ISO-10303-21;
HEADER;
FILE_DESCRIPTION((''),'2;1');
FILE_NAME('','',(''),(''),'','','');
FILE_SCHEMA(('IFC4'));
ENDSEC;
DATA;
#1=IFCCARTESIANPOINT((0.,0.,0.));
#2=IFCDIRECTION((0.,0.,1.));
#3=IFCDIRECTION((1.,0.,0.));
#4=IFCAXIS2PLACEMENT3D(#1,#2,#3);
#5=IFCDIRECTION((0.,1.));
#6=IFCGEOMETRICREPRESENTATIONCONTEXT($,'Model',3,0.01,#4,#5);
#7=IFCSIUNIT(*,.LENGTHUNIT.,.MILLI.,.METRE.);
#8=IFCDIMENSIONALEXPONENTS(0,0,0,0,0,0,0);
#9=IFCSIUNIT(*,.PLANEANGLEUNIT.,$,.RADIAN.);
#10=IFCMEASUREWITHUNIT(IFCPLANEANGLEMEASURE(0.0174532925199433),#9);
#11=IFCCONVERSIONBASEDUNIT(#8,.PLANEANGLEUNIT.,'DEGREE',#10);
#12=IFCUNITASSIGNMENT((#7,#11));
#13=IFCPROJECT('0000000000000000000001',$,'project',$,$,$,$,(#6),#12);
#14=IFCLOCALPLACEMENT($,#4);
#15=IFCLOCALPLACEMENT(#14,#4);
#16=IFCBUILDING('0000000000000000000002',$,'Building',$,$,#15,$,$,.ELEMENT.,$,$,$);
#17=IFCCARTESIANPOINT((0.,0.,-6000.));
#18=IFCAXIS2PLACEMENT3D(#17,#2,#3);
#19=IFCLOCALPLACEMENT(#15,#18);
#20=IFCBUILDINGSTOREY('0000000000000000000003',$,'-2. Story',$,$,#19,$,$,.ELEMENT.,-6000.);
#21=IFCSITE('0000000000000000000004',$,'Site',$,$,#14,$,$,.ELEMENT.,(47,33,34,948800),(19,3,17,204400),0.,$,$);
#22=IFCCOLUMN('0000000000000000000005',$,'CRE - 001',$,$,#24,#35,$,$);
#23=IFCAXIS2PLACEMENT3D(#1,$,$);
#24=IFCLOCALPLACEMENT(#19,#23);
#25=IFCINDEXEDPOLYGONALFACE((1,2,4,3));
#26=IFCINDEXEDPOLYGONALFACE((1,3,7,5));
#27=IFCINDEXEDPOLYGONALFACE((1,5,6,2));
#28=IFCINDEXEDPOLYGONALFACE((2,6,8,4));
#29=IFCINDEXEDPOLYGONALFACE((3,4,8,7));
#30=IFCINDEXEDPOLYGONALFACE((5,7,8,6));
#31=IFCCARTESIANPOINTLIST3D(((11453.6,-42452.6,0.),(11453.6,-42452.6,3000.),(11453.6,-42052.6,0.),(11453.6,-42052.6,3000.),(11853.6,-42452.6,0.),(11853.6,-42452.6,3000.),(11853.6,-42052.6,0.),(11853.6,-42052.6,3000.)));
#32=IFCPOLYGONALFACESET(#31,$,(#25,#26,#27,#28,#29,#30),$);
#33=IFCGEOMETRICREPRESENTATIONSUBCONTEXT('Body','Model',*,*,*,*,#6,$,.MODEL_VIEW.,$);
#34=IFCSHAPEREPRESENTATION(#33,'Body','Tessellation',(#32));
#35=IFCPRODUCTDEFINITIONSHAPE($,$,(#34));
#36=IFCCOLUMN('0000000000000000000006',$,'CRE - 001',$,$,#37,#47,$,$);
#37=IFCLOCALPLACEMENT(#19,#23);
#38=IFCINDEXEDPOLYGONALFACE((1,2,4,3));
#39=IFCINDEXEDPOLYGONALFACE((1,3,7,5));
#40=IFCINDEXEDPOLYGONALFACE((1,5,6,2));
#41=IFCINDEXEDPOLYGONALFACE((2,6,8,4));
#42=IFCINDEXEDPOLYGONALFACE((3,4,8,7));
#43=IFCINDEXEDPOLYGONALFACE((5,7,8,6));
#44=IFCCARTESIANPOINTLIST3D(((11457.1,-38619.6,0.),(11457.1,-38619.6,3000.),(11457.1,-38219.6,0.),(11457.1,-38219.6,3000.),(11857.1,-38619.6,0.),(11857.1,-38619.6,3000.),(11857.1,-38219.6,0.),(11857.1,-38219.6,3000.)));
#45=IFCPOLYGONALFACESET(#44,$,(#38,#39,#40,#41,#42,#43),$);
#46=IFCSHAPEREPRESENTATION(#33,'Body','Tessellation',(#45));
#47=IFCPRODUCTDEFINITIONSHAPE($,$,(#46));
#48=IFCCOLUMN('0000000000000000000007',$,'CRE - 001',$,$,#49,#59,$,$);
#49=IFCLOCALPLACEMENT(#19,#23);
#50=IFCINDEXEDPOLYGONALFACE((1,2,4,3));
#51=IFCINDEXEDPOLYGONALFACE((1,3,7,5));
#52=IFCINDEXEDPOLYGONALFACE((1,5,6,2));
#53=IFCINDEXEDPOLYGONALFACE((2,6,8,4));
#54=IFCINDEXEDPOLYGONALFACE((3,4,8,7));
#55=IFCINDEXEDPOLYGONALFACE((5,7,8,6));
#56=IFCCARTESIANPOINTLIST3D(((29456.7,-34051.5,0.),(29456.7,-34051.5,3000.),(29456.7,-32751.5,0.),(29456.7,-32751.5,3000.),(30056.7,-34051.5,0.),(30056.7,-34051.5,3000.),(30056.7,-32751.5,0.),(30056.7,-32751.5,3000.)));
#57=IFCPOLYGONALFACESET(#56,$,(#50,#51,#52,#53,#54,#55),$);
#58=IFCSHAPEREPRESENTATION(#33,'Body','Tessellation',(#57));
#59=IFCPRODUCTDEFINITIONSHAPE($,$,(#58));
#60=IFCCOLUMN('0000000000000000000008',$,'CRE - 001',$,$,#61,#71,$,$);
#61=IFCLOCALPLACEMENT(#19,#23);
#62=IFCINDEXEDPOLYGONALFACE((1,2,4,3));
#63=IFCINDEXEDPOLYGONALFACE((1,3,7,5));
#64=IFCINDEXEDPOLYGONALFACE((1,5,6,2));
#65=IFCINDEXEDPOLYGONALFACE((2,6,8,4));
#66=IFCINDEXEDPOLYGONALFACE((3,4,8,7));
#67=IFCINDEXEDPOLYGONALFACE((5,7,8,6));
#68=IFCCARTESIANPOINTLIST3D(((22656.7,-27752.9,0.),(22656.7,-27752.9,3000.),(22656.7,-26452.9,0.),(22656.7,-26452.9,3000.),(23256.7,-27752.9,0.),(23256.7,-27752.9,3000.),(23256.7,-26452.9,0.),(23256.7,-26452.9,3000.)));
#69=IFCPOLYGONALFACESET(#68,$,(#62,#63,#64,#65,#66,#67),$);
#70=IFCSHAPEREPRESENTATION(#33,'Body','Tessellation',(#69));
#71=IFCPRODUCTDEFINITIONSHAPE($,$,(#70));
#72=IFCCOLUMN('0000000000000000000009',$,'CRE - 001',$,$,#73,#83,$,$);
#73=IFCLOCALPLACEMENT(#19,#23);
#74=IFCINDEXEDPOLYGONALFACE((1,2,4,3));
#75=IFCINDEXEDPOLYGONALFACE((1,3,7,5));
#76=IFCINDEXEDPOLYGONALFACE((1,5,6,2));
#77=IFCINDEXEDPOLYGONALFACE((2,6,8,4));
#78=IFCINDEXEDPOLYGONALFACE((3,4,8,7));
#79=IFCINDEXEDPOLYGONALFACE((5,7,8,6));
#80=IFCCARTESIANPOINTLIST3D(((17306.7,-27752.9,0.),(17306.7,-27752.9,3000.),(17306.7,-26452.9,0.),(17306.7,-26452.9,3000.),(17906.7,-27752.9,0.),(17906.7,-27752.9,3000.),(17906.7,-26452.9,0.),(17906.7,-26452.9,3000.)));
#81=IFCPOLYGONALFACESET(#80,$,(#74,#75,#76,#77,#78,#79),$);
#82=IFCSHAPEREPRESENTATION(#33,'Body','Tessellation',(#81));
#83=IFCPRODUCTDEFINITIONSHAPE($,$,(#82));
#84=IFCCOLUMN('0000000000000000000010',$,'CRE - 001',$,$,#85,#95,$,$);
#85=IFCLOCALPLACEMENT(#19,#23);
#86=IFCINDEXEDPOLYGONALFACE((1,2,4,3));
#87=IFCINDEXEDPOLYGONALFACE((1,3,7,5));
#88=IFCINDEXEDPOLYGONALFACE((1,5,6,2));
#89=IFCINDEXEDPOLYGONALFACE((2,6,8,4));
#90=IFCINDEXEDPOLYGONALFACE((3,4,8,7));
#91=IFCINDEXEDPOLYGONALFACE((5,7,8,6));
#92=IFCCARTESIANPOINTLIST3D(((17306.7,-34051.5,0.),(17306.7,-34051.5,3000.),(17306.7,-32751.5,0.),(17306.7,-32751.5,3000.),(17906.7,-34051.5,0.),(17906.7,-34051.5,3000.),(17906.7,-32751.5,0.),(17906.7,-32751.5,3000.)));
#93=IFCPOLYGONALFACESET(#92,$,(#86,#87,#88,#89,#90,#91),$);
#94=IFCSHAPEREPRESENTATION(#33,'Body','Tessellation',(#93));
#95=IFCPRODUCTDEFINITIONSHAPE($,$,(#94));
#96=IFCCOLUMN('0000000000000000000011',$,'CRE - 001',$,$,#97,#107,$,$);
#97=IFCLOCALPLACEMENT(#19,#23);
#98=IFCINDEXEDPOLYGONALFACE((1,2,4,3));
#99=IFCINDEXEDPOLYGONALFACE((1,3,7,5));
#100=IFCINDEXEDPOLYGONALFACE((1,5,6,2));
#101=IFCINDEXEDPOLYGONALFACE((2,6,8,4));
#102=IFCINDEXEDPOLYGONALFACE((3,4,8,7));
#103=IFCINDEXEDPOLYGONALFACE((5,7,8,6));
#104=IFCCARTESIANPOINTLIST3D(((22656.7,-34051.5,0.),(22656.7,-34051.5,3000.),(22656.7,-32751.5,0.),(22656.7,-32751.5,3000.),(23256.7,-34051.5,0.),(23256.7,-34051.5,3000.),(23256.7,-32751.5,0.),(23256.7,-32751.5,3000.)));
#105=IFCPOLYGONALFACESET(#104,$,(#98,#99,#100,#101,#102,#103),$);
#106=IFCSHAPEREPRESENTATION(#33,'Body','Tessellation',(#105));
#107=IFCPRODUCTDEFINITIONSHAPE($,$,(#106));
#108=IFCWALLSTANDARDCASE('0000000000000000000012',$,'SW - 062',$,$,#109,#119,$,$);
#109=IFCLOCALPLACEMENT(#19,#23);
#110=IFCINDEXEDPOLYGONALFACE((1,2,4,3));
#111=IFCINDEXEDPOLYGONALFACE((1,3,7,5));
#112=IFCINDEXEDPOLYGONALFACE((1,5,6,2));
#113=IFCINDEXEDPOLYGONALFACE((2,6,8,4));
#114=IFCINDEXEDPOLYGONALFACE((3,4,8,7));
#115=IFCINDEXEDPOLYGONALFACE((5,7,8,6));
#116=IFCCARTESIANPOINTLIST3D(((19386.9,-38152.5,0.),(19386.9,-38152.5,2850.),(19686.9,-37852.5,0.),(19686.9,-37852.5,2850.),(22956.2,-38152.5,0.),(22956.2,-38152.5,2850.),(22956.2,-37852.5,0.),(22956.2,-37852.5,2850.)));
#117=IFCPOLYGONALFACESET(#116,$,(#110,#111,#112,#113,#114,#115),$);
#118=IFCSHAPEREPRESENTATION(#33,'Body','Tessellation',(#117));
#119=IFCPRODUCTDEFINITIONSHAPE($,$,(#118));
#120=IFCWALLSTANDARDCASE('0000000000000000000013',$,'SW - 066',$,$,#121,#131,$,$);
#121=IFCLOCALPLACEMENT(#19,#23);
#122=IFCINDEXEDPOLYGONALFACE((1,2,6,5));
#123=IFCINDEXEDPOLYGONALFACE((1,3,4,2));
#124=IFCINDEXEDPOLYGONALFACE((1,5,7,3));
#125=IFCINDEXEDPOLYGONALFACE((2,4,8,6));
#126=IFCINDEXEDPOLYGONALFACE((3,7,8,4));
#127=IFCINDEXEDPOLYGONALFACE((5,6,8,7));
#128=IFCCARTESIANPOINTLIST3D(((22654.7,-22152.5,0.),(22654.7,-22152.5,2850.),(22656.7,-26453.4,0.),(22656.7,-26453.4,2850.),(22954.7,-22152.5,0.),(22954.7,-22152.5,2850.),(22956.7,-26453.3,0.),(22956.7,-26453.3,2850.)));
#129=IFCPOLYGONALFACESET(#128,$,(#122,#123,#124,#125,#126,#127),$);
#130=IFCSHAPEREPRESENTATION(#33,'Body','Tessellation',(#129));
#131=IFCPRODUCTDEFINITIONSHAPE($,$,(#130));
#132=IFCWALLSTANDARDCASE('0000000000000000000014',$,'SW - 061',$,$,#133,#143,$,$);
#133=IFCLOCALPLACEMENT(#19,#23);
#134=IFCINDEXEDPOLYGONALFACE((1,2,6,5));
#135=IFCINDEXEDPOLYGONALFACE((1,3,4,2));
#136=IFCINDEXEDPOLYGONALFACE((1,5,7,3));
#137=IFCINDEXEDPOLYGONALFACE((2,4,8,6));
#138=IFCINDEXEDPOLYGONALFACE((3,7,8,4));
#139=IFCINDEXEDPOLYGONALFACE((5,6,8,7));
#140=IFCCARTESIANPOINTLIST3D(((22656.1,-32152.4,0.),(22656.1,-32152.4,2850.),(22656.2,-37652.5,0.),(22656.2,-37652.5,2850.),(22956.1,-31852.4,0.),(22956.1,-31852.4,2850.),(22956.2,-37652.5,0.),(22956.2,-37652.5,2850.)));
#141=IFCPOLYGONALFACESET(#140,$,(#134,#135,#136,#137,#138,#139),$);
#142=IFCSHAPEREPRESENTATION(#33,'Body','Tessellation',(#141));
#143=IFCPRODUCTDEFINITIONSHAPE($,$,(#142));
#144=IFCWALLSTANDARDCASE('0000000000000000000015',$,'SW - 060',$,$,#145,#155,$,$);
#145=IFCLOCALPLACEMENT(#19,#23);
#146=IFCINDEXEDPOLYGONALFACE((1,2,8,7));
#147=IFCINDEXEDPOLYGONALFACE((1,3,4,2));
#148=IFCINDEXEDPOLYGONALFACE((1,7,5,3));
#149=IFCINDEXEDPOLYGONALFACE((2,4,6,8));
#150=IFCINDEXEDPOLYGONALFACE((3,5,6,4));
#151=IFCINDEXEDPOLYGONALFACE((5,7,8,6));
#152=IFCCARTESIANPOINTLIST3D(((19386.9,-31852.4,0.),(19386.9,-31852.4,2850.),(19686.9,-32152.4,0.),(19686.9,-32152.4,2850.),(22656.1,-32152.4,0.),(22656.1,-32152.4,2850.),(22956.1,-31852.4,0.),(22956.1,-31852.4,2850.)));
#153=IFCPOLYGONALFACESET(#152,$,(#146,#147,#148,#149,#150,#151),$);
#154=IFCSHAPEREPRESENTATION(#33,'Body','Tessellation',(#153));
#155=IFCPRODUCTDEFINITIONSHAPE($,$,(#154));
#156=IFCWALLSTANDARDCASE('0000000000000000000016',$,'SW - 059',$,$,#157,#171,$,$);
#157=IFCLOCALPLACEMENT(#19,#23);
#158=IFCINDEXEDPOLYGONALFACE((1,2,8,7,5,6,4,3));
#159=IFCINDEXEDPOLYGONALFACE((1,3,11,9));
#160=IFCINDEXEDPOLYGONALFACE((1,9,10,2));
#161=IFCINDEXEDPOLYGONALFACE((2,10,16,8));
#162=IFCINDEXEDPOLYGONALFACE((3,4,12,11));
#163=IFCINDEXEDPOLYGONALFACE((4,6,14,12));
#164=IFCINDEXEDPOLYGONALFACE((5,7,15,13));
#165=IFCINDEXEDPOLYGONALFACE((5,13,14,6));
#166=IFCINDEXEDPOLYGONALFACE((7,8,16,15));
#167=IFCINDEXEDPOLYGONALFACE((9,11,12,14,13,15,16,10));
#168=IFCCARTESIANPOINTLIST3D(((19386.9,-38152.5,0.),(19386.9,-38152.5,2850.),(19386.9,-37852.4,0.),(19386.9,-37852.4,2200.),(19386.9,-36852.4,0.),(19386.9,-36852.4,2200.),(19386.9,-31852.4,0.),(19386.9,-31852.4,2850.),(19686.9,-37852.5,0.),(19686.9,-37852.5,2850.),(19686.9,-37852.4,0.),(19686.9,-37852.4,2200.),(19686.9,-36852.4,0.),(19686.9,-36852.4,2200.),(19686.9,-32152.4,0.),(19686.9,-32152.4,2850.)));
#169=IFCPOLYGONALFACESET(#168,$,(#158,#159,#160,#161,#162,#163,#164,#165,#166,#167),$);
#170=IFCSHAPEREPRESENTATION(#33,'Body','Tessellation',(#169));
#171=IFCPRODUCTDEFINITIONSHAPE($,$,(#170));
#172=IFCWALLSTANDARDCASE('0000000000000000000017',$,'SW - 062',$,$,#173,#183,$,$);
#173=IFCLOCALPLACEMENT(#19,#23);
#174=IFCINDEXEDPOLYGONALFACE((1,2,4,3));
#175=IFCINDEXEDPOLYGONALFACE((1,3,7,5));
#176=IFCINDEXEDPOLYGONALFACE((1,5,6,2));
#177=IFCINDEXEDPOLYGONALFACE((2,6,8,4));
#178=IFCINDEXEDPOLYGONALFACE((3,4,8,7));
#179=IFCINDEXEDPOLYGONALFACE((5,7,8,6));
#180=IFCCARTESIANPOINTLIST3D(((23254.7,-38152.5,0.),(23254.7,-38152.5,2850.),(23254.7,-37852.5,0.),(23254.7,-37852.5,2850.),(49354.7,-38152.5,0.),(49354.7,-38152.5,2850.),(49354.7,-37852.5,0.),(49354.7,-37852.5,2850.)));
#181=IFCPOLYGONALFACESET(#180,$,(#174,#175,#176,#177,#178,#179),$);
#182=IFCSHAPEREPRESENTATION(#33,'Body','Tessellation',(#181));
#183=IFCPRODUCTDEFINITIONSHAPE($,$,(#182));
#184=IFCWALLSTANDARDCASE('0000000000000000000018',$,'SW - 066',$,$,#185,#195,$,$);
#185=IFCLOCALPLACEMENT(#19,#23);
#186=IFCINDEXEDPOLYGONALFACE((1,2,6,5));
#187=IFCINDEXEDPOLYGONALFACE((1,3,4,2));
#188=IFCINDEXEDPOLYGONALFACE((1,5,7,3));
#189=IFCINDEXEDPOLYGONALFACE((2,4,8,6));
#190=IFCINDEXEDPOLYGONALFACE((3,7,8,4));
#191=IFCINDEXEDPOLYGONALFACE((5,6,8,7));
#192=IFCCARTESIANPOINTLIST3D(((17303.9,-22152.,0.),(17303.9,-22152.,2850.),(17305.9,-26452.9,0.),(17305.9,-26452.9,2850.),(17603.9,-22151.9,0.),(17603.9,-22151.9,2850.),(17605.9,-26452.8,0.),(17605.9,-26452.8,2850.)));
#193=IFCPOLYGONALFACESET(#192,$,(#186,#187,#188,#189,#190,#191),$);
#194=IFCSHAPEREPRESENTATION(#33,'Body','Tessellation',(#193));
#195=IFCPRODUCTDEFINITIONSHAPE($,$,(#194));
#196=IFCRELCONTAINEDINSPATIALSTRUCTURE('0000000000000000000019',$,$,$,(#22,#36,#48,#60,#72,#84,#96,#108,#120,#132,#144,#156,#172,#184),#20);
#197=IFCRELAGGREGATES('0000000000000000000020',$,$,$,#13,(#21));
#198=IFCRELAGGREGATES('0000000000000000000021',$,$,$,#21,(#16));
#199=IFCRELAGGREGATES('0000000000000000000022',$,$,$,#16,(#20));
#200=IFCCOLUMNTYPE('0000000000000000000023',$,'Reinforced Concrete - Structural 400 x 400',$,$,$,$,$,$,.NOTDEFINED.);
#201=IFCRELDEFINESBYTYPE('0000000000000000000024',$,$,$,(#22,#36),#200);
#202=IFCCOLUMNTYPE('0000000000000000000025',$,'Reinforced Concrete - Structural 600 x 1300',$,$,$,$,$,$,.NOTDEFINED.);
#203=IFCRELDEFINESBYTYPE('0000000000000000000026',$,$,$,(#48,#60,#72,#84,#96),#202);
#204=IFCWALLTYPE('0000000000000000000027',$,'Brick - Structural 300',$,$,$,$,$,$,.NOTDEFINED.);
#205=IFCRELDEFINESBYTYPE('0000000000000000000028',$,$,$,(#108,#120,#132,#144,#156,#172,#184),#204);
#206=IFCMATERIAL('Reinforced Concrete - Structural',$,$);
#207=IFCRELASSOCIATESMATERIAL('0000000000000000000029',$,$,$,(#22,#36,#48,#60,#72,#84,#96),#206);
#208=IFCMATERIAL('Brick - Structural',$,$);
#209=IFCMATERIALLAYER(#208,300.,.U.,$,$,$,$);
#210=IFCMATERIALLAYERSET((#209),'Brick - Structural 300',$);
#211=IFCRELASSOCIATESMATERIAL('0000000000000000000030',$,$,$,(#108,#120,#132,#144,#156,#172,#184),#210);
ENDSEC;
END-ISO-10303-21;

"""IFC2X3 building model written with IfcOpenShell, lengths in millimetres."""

from ifc_helpers import new_model, entity, si_unit, converted_unit, direction, frame, origin_with_axes, origin_2d_with_axis, place, context, subcontext, project, spatial, polyline, rectangle, outline, extrude, material, layer, layer_set, layer_usage, type_object, element, save


model = new_model("IFC2X3")

# Units and contexts
model_context = context("Model", 3, precision=0.01, world=origin_with_axes(), true_north=direction((0.0, 1.0)))
body_context = subcontext(model_context, "Body", "Model", "MODEL_VIEW")
ifc_project = project(units=[si_unit("LENGTHUNIT", "METRE", prefix="MILLI"), converted_unit("PLANEANGLEUNIT", "DEGREE", entity("IfcPlaneAngleMeasure", 0.0174532925199433), si_unit("PLANEANGLEUNIT", "RADIAN"), dimensions=[0, 0, 0, 0, 0, 0, 0])], contexts=[model_context])

# Site, building, storey
site_placement = place(None, origin_with_axes())
site = spatial("IfcSite", under=ifc_project, at=site_placement, Name="Site", CompositionType="ELEMENT", RefLatitude=(47, 33, 34, 948800), RefLongitude=(19, 3, 17, 204400), RefElevation=0.0)
building_placement = place(site_placement, origin_with_axes())
building = spatial("IfcBuilding", under=site, at=building_placement, Name="Building", CompositionType="ELEMENT")
storey_placement = place(building_placement, frame((0.0, 0.0, -6000.0), z_axis=(0.0, 0.0, 1.0), x_axis=(1.0, 0.0, 0.0)))
storey = spatial("IfcBuildingStorey", under=building, at=storey_placement, Name="-2. Story", CompositionType="ELEMENT", Elevation=-6000.0)

# Columns
ifc_material_1 = material(Name="Reinforced Concrete - Structural")
column_type_1 = type_object("IfcColumnType", Name="Reinforced Concrete - Structural 400 x 400", PredefinedType="NOTDEFINED")
for number, where, z_axis, x_axis, name in (
    (1, (11653.6, -42252.6, 0.0), (0.0, 0.0, 1.0), (1.0, 0.0, 0.0), "CRE - 001"),
    (2, (11657.1, -38419.6, 0.0), (0.0, 0.0, 1.0), (1.0, 0.0, 0.0), "CRE - 001"),
):
    element("IfcColumn", number, at=place(storey_placement, frame(where, z_axis=z_axis, x_axis=x_axis)), inside=storey, type_object=column_type_1, material=ifc_material_1, Name=name, context=body_context, shape_type="SweptSolid", body=[
        extrude(rectangle(XDim=400.0, YDim=400.0, at=origin_2d_with_axis()), origin_with_axes(), (0.0, 0.0, 1.0), 3000.0),
    ])
column_type_2 = type_object("IfcColumnType", Name="Reinforced Concrete - Structural 600 x 1300", PredefinedType="NOTDEFINED")
for number, where, z_axis, x_axis, name in (
    (3, (29756.7, -33401.5, 0.0), (0.0, 0.0, 1.0), (1.0, 0.0, 0.0), "CRE - 001"),
    (4, (22956.7, -27102.9, 0.0), (0.0, 0.0, 1.0), (1.0, 0.0, 0.0), "CRE - 001"),
    (5, (17606.7, -27102.9, 0.0), (0.0, 0.0, 1.0), (1.0, 0.0, 0.0), "CRE - 001"),
    (6, (17606.7, -33401.5, 0.0), (0.0, 0.0, 1.0), (1.0, 0.0, 0.0), "CRE - 001"),
    (7, (22956.7, -33401.5, 0.0), (0.0, 0.0, 1.0), (1.0, 0.0, 0.0), "CRE - 001"),
):
    element("IfcColumn", number, at=place(storey_placement, frame(where, z_axis=z_axis, x_axis=x_axis)), inside=storey, type_object=column_type_2, material=ifc_material_1, Name=name, context=body_context, shape_type="SweptSolid", body=[
        extrude(rectangle(XDim=600.0, YDim=1300.0, at=origin_2d_with_axis()), origin_with_axes(), (0.0, 0.0, 1.0), 3000.0),
    ])

# Walls
ifc_material_2 = material(Name="Brick - Structural")
ifc_layer_1 = layer(ifc_material_2, 300.0, ventilated="UNKNOWN")
ifc_layer_set_1 = layer_set([ifc_layer_1], Name="Brick - Structural 300")
ifc_layer_usage_1 = layer_usage(ifc_layer_set_1, "AXIS2", "NEGATIVE", 0.0)
wall_type_1 = type_object("IfcWallType", Name="Brick - Structural 300", PredefinedType="NOTDEFINED")
wall_1_placement = place(storey_placement, frame((22956.2, -38152.5, 0.0), z_axis=(0.0, 0.0, 1.0), x_axis=(-1.0, 0.0, 0.0)))
element("IfcWallStandardCase", 8, at=wall_1_placement, inside=storey, type_object=wall_type_1, material=ifc_layer_usage_1, Name="SW - 062", context=body_context, shape_type="SweptSolid", body=[
    extrude(outline(polyline([(0.0, -300.0), (3269.3, -300.0), (3569.3, 0.0), (0.0, 0.0), (0.0, -300.0)])), origin_with_axes(), (0.0, 0.0, 1.0), 2850.0),
])
ifc_layer_usage_2 = layer_usage(ifc_layer_set_1, "AXIS2", "POSITIVE", 0.0)
wall_2_placement = place(storey_placement, frame((22654.7, -22152.5, 0.0), z_axis=(0.0, 0.0, 1.0), x_axis=(0.000477, -1.0, 0.0)))
element("IfcWallStandardCase", 9, at=wall_2_placement, inside=storey, type_object=wall_type_1, material=ifc_layer_usage_2, Name="SW - 066", context=body_context, shape_type="SweptSolid", body=[
    extrude(outline(polyline([(0.0, 0.0), (4300.9, 0.0), (4300.9, 300.0), (0.1, 300.0), (0.0, 0.0)])), origin_with_axes(), (0.0, 0.0, 1.0), 2850.0),
])
ifc_layer_usage_3 = layer_usage(ifc_layer_set_1, "AXIS2", "NEGATIVE", 0.0)
wall_3_placement = place(storey_placement, frame((22956.1, -31852.4, 0.0), z_axis=(0.0, 0.0, 1.0), x_axis=(0.00002, -1.0, 0.0)))
element("IfcWallStandardCase", 10, at=wall_3_placement, inside=storey, type_object=wall_type_1, material=ifc_layer_usage_3, Name="SW - 061", context=body_context, shape_type="SweptSolid", body=[
    extrude(outline(polyline([(300.0, -300.0), (5800.1, -300.0), (5800.1, 0.0), (0.0, 0.0), (300.0, -300.0)])), origin_with_axes(), (0.0, 0.0, 1.0), 2850.0),
])
ifc_layer_usage_4 = layer_usage(ifc_layer_set_1, "AXIS2", "NEGATIVE", 0.0)
wall_4_placement = place(storey_placement, frame((19386.9, -31852.4, 0.0), z_axis=(0.0, 0.0, 1.0), x_axis=(1.0, 0.0, 0.0)))
element("IfcWallStandardCase", 11, at=wall_4_placement, inside=storey, type_object=wall_type_1, material=ifc_layer_usage_4, Name="SW - 060", context=body_context, shape_type="SweptSolid", body=[
    extrude(outline(polyline([(300.0, -300.0), (3269.2, -300.0), (3569.2, 0.0), (0.0, 0.0), (300.0, -300.0)])), origin_with_axes(), (0.0, 0.0, 1.0), 2850.0),
])

# Wall, opening
ifc_layer_usage_5 = layer_usage(ifc_layer_set_1, "AXIS2", "NEGATIVE", 0.0)
wall_5_placement = place(storey_placement, frame((19386.9, -38152.5, 0.0), z_axis=(0.0, 0.0, 1.0), x_axis=(0.0, 1.0, 0.0)))
wall_5 = element("IfcWallStandardCase", 12, at=wall_5_placement, inside=storey, type_object=wall_type_1, material=ifc_layer_usage_5, Name="SW - 059", context=body_context, shape_type="SweptSolid", body=[
    extrude(outline(polyline([(300.0, -300.0), (6000.1, -300.0), (6300.1, 0.0), (0.0, 0.0), (300.0, -300.0)])), origin_with_axes(), (0.0, 0.0, 1.0), 2850.0),
])
opening_1_placement = place(wall_5_placement, frame((800.0, 0.0, 0.0), z_axis=(0.0, 0.0, 1.0), x_axis=(1.0, 0.0, 0.0)))
element("IfcOpeningElement", 13, at=opening_1_placement, cuts=wall_5, context=body_context, shape_type="SweptSolid", body=[
    extrude(rectangle(XDim=1000.0, YDim=2200.0, at=origin_2d_with_axis()), frame((0.0, 0.0, 1100.0), z_axis=(0.0, -1.0, 0.0), x_axis=(1.0, 0.0, 0.0)), (0.0, 0.0, -1.0), 300.0),
    extrude(rectangle(XDim=1000.0, YDim=2200.0, at=origin_2d_with_axis()), frame((0.0, 0.0, 1100.0), z_axis=(0.0, 1.0, 0.0), x_axis=(1.0, 0.0, 0.0)), (0.0, 0.0, -1.0), 300.0),
])

# Walls
ifc_layer_usage_6 = layer_usage(ifc_layer_set_1, "AXIS2", "POSITIVE", 0.0)
wall_6_placement = place(storey_placement, frame((23254.7, -38152.5, 0.0), z_axis=(0.0, 0.0, 1.0), x_axis=(1.0, 0.0, 0.0)))
element("IfcWallStandardCase", 14, at=wall_6_placement, inside=storey, type_object=wall_type_1, material=ifc_layer_usage_6, Name="SW - 062", context=body_context, shape_type="SweptSolid", body=[
    extrude(outline(polyline([(0.0, 0.0), (26100.0, 0.0), (26100.0, 300.0), (0.0, 300.0), (0.0, 0.0)])), origin_with_axes(), (0.0, 0.0, 1.0), 2850.0),
])
ifc_layer_usage_7 = layer_usage(ifc_layer_set_1, "AXIS2", "POSITIVE", 0.0)
wall_7_placement = place(storey_placement, frame((17303.9, -22152.0, 0.0), z_axis=(0.0, 0.0, 1.0), x_axis=(0.000477, -1.0, 0.0)))
element("IfcWallStandardCase", 15, at=wall_7_placement, inside=storey, type_object=wall_type_1, material=ifc_layer_usage_7, Name="SW - 066", context=body_context, shape_type="SweptSolid", body=[
    extrude(outline(polyline([(0.0, 0.0), (4300.9, 0.0), (4300.9, 300.0), (0.0, 300.0), (0.0, 0.0)])), origin_with_axes(), (0.0, 0.0, 1.0), 2850.0),
])

save(model, "model.ifc")
